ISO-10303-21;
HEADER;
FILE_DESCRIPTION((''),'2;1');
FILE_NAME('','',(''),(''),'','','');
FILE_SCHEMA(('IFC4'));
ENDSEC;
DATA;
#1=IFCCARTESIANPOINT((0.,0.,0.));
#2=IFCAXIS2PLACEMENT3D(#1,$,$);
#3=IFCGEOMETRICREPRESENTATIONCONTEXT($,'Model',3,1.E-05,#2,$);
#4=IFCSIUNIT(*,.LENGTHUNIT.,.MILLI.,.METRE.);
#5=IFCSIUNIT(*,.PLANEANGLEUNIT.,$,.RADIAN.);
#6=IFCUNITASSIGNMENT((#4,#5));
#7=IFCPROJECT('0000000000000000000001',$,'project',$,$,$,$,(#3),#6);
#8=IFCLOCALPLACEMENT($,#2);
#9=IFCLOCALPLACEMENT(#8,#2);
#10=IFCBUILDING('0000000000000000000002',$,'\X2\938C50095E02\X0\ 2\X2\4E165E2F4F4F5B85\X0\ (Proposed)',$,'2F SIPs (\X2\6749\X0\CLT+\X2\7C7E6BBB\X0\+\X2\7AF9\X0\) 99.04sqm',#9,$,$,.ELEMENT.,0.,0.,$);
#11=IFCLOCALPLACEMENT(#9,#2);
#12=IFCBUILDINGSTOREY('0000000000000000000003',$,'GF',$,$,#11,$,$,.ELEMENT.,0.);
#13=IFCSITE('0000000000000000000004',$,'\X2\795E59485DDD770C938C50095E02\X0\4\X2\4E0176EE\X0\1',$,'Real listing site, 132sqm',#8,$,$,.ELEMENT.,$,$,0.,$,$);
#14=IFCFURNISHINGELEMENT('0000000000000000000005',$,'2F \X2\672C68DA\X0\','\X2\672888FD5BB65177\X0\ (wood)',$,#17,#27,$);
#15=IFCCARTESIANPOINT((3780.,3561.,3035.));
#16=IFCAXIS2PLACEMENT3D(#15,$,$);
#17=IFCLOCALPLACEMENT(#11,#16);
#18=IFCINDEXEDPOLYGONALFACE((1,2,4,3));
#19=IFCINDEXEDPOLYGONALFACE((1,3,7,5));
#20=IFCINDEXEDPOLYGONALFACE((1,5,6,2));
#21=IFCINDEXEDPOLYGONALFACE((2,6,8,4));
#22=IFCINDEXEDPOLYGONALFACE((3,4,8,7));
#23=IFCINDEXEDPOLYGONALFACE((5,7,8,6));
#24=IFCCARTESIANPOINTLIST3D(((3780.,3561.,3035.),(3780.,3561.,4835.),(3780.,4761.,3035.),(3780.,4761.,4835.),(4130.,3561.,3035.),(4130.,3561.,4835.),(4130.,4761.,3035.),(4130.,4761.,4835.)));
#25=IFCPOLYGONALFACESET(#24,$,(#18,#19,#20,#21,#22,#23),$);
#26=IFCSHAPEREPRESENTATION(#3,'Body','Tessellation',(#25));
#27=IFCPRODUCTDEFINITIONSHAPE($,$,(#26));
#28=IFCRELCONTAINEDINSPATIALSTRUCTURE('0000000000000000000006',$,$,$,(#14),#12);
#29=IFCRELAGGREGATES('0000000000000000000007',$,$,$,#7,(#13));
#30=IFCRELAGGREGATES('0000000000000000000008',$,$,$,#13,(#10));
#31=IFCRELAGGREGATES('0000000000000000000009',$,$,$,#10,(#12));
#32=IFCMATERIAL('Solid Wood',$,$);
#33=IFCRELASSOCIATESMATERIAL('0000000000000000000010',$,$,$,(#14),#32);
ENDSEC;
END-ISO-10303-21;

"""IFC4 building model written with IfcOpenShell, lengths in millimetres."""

from ifc_helpers import new_model, si_unit, frame, frame_2d, origin, place, context, project, spatial, rectangle, extrude, material, element, save


model = new_model("IFC4")

# Units and contexts
model_context = context("Model", 3, precision=1e-05, world=origin())
ifc_project = project(units=[si_unit("LENGTHUNIT", "METRE", prefix="MILLI"), si_unit("PLANEANGLEUNIT", "RADIAN")], contexts=[model_context])

# Site, building, storey
site_placement = place(None, origin())
site = spatial("IfcSite", under=ifc_project, at=site_placement, Name="神奈川県鎌倉市4丁目1", ObjectType="Real listing site, 132sqm", CompositionType="ELEMENT", RefElevation=0.0)
building_placement = place(site_placement, origin())
building = spatial("IfcBuilding", under=site, at=building_placement, Name="鎌倉市 2世帯住宅 (Proposed)", ObjectType="2F SIPs (杉CLT+籾殻+竹) 99.04sqm", CompositionType="ELEMENT", ElevationOfRefHeight=0.0, ElevationOfTerrain=0.0)
storey_placement = place(building_placement, origin())
storey = spatial("IfcBuildingStorey", under=building, at=storey_placement, Name="GF", CompositionType="ELEMENT", Elevation=0.0)

# Shared definitions
ifc_material_1 = material(Name="Solid Wood")

# Furnishing element
furnishing_placement = place(storey_placement, frame((3780.0, 3561.0, 3035.0)))
element("IfcFurnishingElement", 1, at=furnishing_placement, inside=storey, material=ifc_material_1, Name="2F 本棚", Description="木製家具 (wood)", context=model_context, shape_type="SweptSolid", body=[
    extrude(rectangle(XDim=350.0, YDim=1200.0, at=frame_2d((175.0, 600.0))), frame((3780.0, 3561.0, 3035.0)), (0.0, 0.0, 1.0), 1800.0),
])

save(model, "model.ifc")
